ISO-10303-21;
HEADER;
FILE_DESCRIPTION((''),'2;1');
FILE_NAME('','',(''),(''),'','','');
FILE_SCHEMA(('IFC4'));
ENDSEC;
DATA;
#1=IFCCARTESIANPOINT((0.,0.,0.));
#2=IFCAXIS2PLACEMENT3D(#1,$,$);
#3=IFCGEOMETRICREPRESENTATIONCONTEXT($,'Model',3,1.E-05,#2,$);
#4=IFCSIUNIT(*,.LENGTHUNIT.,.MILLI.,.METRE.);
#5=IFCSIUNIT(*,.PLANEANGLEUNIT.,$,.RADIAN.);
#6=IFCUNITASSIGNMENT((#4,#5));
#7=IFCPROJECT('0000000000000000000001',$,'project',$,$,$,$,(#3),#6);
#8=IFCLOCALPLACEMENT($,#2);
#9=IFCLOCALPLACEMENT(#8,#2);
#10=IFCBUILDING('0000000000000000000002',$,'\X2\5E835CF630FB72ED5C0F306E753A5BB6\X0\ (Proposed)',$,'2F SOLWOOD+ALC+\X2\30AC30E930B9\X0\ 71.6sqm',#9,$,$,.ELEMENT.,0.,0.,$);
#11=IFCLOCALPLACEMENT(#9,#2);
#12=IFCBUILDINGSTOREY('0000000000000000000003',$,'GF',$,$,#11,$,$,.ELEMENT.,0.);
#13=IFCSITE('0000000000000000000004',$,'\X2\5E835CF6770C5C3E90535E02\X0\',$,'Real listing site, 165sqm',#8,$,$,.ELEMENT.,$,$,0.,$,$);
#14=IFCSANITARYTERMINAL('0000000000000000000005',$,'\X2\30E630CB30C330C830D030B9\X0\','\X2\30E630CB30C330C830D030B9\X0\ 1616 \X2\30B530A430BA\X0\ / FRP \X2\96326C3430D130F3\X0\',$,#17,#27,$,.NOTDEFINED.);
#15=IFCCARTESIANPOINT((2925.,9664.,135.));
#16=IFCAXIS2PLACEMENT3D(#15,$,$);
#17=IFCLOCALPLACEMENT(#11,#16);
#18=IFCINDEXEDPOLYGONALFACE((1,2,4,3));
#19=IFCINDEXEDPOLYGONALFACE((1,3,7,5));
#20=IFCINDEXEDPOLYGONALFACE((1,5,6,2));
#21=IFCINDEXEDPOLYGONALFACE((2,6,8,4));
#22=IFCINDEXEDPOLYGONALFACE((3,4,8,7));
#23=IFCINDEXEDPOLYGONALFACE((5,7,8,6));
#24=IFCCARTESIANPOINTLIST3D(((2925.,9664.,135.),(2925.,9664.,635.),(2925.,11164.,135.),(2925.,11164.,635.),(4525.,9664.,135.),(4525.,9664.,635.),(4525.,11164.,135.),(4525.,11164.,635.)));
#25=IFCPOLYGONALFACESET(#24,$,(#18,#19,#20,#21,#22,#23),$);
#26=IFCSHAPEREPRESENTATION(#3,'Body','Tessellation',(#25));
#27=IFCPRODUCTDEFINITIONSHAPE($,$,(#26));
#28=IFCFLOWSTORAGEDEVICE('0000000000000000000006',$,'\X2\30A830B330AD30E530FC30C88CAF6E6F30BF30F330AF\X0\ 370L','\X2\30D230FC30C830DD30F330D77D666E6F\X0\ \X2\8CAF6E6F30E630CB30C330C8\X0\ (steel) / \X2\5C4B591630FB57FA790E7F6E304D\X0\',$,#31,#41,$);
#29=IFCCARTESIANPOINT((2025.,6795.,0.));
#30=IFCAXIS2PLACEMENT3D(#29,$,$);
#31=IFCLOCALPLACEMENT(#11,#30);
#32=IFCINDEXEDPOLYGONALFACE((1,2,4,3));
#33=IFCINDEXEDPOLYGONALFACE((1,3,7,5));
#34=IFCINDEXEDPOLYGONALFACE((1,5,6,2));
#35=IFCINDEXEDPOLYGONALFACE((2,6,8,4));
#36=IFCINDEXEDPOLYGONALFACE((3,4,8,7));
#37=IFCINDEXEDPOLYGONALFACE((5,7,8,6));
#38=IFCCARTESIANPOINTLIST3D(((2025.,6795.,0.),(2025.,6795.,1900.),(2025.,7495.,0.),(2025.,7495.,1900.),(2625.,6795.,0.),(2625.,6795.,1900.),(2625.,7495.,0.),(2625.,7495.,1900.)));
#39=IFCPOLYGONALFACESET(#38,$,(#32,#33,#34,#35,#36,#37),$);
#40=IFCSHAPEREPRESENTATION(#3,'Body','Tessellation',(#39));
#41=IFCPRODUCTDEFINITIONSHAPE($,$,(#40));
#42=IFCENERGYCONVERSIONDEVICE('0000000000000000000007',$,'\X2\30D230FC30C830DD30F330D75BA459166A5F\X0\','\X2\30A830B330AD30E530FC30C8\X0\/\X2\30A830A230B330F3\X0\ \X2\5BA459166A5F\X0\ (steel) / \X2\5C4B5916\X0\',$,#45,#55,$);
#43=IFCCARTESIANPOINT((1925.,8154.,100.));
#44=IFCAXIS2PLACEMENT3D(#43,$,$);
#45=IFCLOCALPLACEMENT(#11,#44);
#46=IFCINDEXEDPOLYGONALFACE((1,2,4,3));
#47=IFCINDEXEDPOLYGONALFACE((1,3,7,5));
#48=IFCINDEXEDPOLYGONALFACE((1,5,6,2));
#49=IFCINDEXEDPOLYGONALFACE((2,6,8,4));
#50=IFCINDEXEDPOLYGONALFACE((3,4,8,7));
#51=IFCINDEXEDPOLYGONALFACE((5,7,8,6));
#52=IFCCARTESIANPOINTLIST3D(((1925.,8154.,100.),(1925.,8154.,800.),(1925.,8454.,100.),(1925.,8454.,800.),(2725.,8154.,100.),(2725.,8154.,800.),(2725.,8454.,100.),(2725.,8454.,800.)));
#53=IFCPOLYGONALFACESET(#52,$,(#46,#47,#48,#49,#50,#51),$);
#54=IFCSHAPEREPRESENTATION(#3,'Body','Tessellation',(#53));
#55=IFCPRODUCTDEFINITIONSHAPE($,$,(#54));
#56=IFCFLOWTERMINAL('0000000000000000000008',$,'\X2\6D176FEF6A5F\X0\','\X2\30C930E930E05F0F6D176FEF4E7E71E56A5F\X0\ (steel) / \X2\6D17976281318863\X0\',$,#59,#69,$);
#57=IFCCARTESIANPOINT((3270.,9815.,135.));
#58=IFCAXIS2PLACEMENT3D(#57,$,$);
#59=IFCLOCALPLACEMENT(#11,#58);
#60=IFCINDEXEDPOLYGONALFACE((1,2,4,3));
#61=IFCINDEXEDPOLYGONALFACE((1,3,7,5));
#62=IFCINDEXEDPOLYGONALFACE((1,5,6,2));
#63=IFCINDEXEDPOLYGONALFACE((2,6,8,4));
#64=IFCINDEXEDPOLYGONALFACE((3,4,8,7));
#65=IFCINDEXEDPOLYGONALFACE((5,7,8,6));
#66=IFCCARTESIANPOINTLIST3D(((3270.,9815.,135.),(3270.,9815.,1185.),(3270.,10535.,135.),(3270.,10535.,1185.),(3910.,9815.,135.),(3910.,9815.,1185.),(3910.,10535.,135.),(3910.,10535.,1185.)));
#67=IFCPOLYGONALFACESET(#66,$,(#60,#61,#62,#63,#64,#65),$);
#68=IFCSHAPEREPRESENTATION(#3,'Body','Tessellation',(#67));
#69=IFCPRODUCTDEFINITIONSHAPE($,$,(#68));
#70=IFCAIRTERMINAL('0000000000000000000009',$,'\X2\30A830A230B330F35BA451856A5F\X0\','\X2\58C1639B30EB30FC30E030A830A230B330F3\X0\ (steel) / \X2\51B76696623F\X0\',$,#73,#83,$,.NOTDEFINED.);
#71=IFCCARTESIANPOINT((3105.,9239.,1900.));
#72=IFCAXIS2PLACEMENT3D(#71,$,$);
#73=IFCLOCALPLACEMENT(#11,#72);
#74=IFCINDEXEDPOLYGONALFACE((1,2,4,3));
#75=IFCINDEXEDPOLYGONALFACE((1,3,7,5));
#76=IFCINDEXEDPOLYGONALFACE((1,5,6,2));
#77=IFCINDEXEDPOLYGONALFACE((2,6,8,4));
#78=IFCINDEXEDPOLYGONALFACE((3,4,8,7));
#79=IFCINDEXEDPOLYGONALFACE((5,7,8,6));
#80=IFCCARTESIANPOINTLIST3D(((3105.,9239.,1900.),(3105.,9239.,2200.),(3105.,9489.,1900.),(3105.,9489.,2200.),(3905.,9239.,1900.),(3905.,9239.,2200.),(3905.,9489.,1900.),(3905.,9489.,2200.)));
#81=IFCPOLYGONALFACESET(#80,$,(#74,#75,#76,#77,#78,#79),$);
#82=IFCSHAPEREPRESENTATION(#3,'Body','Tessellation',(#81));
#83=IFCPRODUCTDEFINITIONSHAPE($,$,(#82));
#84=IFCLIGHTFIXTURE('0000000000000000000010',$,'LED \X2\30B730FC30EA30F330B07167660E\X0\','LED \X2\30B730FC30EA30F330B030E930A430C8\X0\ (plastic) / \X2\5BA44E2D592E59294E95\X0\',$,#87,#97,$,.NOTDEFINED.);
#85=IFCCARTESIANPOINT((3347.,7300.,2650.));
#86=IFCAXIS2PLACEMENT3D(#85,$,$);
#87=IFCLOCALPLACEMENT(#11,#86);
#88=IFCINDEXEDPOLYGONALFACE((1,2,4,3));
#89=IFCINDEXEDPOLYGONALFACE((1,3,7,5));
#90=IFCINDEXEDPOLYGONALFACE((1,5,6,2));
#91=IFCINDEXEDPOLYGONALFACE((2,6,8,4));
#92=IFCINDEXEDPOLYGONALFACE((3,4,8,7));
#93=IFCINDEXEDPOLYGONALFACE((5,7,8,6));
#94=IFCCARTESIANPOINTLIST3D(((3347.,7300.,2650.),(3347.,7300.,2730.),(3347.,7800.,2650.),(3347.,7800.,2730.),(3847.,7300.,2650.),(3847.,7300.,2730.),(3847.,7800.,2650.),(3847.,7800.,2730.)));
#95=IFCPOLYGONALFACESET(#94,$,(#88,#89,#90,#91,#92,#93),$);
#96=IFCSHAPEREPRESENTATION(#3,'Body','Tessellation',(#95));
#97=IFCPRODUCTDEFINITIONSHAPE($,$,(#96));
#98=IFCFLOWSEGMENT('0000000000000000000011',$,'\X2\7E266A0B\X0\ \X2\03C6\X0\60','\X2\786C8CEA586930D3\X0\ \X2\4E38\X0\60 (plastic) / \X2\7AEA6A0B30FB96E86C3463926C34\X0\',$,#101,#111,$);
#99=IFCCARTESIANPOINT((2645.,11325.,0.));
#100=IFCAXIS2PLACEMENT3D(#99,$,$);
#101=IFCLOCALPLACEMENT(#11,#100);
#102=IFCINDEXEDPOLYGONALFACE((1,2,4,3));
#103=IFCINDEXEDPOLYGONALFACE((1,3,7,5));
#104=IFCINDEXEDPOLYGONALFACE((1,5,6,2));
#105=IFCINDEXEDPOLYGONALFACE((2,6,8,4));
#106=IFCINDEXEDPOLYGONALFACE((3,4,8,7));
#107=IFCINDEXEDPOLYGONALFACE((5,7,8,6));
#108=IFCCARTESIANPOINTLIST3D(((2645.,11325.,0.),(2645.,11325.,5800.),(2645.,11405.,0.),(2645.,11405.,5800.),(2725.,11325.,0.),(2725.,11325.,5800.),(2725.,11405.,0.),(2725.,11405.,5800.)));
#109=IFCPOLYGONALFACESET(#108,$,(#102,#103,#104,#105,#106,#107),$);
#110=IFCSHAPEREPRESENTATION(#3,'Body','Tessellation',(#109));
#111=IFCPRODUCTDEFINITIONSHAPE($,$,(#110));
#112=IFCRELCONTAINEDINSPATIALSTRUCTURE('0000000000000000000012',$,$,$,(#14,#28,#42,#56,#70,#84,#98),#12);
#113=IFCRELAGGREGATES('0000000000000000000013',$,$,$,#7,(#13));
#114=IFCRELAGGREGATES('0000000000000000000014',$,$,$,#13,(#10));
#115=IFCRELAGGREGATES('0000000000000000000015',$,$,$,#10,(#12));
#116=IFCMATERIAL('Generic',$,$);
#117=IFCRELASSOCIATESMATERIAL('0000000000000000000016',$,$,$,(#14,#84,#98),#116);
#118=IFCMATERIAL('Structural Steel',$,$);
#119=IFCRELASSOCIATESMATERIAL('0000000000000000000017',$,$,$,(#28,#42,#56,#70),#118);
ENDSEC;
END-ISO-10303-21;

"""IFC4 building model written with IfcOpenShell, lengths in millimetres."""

from ifc_helpers import new_model, si_unit, frame, frame_2d, origin, place, context, project, spatial, rectangle, extrude, material, element, save


model = new_model("IFC4")

# Units and contexts
model_context = context("Model", 3, precision=1e-05, world=origin())
ifc_project = project(units=[si_unit("LENGTHUNIT", "METRE", prefix="MILLI"), si_unit("PLANEANGLEUNIT", "RADIAN")], contexts=[model_context])

# Site, building, storey
site_placement = place(None, origin())
site = spatial("IfcSite", under=ifc_project, at=site_placement, Name="広島県尾道市", ObjectType="Real listing site, 165sqm", CompositionType="ELEMENT", RefElevation=0.0)
building_placement = place(site_placement, origin())
building = spatial("IfcBuilding", under=site, at=building_placement, Name="広島・狭小の町家 (Proposed)", ObjectType="2F SOLWOOD+ALC+ガラス 71.6sqm", CompositionType="ELEMENT", ElevationOfRefHeight=0.0, ElevationOfTerrain=0.0)
storey_placement = place(building_placement, origin())
storey = spatial("IfcBuildingStorey", under=building, at=storey_placement, Name="GF", CompositionType="ELEMENT", Elevation=0.0)

# Shared definitions
ifc_material_1 = material(Name="Generic")

# Sanitary terminal
sanitary_terminal_placement = place(storey_placement, frame((2925.0, 9664.0, 135.0)))
element("IfcSanitaryTerminal", 1, at=sanitary_terminal_placement, inside=storey, material=ifc_material_1, Name="ユニットバス", Description="ユニットバス 1616 サイズ / FRP 防水パン", PredefinedType="NOTDEFINED", context=model_context, shape_type="SweptSolid", body=[
    extrude(rectangle(XDim=1600.0, YDim=1500.0, at=frame_2d((800.0, 750.0))), frame((2925.0, 9664.0, 135.0)), (0.0, 0.0, 1.0), 500.0),
])

# Flow storage device
ifc_material_2 = material(Name="Structural Steel")
flow_storage_device_placement = place(storey_placement, frame((2025.0, 6795.0, 0.0)))
element("IfcFlowStorageDevice", 2, at=flow_storage_device_placement, inside=storey, material=ifc_material_2, Name="エコキュート貯湯タンク 370L", Description="ヒートポンプ給湯 貯湯ユニット (steel) / 屋外・基礎置き", context=model_context, shape_type="SweptSolid", body=[
    extrude(rectangle(XDim=600.0, YDim=700.0, at=frame_2d((300.0, 350.0))), frame((2025.0, 6795.0, 0.0)), (0.0, 0.0, 1.0), 1900.0),
])

# Energy conversion device
energy_conversion_device_placement = place(storey_placement, frame((1925.0, 8154.0, 100.0)))
element("IfcEnergyConversionDevice", 3, at=energy_conversion_device_placement, inside=storey, material=ifc_material_2, Name="ヒートポンプ室外機", Description="エコキュート/エアコン 室外機 (steel) / 屋外", context=model_context, shape_type="SweptSolid", body=[
    extrude(rectangle(XDim=800.0, YDim=300.0, at=frame_2d((400.0, 150.0))), frame((1925.0, 8154.0, 100.0)), (0.0, 0.0, 1.0), 700.0),
])

# Flow terminal
flow_terminal_placement = place(storey_placement, frame((3270.0, 9815.0, 135.0)))
element("IfcFlowTerminal", 4, at=flow_terminal_placement, inside=storey, material=ifc_material_2, Name="洗濯機", Description="ドラム式洗濯乾燥機 (steel) / 洗面脱衣", context=model_context, shape_type="SweptSolid", body=[
    extrude(rectangle(XDim=640.0, YDim=720.0, at=frame_2d((320.0, 360.0))), frame((3270.0, 9815.0, 135.0)), (0.0, 0.0, 1.0), 1050.0),
])

# Air terminal
air_terminal_placement = place(storey_placement, frame((3105.0, 9239.0, 1900.0)))
element("IfcAirTerminal", 5, at=air_terminal_placement, inside=storey, material=ifc_material_2, Name="エアコン室内機", Description="壁掛ルームエアコン (steel) / 冷暖房", PredefinedType="NOTDEFINED", context=model_context, shape_type="SweptSolid", body=[
    extrude(rectangle(XDim=800.0, YDim=250.0, at=frame_2d((400.0, 125.0))), frame((3105.0, 9239.0, 1900.0)), (0.0, 0.0, 1.0), 300.0),
])

# Light fixture
light_fixture_placement = place(storey_placement, frame((3347.0, 7300.0, 2650.0)))
element("IfcLightFixture", 6, at=light_fixture_placement, inside=storey, material=ifc_material_1, Name="LED シーリング照明", Description="LED シーリングライト (plastic) / 室中央天井", PredefinedType="NOTDEFINED", context=model_context, shape_type="SweptSolid", body=[
    extrude(rectangle(XDim=500.0, YDim=500.0, at=frame_2d((250.0, 250.0))), frame((3347.0, 7300.0, 2650.0)), (0.0, 0.0, 1.0), 80.0),
])

# Flow segment
flow_segment_placement = place(storey_placement, frame((2645.0, 11325.0, 0.0)))
element("IfcFlowSegment", 7, at=flow_segment_placement, inside=storey, material=ifc_material_1, Name="縦樋 φ60", Description="硬質塩ビ 丸60 (plastic) / 竪樋・雨水排水", context=model_context, shape_type="SweptSolid", body=[
    extrude(rectangle(XDim=80.0, YDim=80.0, at=frame_2d((40.0, 40.0))), frame((2645.0, 11325.0, 0.0)), (0.0, 0.0, 1.0), 5800.0),
])

save(model, "model.ifc")
